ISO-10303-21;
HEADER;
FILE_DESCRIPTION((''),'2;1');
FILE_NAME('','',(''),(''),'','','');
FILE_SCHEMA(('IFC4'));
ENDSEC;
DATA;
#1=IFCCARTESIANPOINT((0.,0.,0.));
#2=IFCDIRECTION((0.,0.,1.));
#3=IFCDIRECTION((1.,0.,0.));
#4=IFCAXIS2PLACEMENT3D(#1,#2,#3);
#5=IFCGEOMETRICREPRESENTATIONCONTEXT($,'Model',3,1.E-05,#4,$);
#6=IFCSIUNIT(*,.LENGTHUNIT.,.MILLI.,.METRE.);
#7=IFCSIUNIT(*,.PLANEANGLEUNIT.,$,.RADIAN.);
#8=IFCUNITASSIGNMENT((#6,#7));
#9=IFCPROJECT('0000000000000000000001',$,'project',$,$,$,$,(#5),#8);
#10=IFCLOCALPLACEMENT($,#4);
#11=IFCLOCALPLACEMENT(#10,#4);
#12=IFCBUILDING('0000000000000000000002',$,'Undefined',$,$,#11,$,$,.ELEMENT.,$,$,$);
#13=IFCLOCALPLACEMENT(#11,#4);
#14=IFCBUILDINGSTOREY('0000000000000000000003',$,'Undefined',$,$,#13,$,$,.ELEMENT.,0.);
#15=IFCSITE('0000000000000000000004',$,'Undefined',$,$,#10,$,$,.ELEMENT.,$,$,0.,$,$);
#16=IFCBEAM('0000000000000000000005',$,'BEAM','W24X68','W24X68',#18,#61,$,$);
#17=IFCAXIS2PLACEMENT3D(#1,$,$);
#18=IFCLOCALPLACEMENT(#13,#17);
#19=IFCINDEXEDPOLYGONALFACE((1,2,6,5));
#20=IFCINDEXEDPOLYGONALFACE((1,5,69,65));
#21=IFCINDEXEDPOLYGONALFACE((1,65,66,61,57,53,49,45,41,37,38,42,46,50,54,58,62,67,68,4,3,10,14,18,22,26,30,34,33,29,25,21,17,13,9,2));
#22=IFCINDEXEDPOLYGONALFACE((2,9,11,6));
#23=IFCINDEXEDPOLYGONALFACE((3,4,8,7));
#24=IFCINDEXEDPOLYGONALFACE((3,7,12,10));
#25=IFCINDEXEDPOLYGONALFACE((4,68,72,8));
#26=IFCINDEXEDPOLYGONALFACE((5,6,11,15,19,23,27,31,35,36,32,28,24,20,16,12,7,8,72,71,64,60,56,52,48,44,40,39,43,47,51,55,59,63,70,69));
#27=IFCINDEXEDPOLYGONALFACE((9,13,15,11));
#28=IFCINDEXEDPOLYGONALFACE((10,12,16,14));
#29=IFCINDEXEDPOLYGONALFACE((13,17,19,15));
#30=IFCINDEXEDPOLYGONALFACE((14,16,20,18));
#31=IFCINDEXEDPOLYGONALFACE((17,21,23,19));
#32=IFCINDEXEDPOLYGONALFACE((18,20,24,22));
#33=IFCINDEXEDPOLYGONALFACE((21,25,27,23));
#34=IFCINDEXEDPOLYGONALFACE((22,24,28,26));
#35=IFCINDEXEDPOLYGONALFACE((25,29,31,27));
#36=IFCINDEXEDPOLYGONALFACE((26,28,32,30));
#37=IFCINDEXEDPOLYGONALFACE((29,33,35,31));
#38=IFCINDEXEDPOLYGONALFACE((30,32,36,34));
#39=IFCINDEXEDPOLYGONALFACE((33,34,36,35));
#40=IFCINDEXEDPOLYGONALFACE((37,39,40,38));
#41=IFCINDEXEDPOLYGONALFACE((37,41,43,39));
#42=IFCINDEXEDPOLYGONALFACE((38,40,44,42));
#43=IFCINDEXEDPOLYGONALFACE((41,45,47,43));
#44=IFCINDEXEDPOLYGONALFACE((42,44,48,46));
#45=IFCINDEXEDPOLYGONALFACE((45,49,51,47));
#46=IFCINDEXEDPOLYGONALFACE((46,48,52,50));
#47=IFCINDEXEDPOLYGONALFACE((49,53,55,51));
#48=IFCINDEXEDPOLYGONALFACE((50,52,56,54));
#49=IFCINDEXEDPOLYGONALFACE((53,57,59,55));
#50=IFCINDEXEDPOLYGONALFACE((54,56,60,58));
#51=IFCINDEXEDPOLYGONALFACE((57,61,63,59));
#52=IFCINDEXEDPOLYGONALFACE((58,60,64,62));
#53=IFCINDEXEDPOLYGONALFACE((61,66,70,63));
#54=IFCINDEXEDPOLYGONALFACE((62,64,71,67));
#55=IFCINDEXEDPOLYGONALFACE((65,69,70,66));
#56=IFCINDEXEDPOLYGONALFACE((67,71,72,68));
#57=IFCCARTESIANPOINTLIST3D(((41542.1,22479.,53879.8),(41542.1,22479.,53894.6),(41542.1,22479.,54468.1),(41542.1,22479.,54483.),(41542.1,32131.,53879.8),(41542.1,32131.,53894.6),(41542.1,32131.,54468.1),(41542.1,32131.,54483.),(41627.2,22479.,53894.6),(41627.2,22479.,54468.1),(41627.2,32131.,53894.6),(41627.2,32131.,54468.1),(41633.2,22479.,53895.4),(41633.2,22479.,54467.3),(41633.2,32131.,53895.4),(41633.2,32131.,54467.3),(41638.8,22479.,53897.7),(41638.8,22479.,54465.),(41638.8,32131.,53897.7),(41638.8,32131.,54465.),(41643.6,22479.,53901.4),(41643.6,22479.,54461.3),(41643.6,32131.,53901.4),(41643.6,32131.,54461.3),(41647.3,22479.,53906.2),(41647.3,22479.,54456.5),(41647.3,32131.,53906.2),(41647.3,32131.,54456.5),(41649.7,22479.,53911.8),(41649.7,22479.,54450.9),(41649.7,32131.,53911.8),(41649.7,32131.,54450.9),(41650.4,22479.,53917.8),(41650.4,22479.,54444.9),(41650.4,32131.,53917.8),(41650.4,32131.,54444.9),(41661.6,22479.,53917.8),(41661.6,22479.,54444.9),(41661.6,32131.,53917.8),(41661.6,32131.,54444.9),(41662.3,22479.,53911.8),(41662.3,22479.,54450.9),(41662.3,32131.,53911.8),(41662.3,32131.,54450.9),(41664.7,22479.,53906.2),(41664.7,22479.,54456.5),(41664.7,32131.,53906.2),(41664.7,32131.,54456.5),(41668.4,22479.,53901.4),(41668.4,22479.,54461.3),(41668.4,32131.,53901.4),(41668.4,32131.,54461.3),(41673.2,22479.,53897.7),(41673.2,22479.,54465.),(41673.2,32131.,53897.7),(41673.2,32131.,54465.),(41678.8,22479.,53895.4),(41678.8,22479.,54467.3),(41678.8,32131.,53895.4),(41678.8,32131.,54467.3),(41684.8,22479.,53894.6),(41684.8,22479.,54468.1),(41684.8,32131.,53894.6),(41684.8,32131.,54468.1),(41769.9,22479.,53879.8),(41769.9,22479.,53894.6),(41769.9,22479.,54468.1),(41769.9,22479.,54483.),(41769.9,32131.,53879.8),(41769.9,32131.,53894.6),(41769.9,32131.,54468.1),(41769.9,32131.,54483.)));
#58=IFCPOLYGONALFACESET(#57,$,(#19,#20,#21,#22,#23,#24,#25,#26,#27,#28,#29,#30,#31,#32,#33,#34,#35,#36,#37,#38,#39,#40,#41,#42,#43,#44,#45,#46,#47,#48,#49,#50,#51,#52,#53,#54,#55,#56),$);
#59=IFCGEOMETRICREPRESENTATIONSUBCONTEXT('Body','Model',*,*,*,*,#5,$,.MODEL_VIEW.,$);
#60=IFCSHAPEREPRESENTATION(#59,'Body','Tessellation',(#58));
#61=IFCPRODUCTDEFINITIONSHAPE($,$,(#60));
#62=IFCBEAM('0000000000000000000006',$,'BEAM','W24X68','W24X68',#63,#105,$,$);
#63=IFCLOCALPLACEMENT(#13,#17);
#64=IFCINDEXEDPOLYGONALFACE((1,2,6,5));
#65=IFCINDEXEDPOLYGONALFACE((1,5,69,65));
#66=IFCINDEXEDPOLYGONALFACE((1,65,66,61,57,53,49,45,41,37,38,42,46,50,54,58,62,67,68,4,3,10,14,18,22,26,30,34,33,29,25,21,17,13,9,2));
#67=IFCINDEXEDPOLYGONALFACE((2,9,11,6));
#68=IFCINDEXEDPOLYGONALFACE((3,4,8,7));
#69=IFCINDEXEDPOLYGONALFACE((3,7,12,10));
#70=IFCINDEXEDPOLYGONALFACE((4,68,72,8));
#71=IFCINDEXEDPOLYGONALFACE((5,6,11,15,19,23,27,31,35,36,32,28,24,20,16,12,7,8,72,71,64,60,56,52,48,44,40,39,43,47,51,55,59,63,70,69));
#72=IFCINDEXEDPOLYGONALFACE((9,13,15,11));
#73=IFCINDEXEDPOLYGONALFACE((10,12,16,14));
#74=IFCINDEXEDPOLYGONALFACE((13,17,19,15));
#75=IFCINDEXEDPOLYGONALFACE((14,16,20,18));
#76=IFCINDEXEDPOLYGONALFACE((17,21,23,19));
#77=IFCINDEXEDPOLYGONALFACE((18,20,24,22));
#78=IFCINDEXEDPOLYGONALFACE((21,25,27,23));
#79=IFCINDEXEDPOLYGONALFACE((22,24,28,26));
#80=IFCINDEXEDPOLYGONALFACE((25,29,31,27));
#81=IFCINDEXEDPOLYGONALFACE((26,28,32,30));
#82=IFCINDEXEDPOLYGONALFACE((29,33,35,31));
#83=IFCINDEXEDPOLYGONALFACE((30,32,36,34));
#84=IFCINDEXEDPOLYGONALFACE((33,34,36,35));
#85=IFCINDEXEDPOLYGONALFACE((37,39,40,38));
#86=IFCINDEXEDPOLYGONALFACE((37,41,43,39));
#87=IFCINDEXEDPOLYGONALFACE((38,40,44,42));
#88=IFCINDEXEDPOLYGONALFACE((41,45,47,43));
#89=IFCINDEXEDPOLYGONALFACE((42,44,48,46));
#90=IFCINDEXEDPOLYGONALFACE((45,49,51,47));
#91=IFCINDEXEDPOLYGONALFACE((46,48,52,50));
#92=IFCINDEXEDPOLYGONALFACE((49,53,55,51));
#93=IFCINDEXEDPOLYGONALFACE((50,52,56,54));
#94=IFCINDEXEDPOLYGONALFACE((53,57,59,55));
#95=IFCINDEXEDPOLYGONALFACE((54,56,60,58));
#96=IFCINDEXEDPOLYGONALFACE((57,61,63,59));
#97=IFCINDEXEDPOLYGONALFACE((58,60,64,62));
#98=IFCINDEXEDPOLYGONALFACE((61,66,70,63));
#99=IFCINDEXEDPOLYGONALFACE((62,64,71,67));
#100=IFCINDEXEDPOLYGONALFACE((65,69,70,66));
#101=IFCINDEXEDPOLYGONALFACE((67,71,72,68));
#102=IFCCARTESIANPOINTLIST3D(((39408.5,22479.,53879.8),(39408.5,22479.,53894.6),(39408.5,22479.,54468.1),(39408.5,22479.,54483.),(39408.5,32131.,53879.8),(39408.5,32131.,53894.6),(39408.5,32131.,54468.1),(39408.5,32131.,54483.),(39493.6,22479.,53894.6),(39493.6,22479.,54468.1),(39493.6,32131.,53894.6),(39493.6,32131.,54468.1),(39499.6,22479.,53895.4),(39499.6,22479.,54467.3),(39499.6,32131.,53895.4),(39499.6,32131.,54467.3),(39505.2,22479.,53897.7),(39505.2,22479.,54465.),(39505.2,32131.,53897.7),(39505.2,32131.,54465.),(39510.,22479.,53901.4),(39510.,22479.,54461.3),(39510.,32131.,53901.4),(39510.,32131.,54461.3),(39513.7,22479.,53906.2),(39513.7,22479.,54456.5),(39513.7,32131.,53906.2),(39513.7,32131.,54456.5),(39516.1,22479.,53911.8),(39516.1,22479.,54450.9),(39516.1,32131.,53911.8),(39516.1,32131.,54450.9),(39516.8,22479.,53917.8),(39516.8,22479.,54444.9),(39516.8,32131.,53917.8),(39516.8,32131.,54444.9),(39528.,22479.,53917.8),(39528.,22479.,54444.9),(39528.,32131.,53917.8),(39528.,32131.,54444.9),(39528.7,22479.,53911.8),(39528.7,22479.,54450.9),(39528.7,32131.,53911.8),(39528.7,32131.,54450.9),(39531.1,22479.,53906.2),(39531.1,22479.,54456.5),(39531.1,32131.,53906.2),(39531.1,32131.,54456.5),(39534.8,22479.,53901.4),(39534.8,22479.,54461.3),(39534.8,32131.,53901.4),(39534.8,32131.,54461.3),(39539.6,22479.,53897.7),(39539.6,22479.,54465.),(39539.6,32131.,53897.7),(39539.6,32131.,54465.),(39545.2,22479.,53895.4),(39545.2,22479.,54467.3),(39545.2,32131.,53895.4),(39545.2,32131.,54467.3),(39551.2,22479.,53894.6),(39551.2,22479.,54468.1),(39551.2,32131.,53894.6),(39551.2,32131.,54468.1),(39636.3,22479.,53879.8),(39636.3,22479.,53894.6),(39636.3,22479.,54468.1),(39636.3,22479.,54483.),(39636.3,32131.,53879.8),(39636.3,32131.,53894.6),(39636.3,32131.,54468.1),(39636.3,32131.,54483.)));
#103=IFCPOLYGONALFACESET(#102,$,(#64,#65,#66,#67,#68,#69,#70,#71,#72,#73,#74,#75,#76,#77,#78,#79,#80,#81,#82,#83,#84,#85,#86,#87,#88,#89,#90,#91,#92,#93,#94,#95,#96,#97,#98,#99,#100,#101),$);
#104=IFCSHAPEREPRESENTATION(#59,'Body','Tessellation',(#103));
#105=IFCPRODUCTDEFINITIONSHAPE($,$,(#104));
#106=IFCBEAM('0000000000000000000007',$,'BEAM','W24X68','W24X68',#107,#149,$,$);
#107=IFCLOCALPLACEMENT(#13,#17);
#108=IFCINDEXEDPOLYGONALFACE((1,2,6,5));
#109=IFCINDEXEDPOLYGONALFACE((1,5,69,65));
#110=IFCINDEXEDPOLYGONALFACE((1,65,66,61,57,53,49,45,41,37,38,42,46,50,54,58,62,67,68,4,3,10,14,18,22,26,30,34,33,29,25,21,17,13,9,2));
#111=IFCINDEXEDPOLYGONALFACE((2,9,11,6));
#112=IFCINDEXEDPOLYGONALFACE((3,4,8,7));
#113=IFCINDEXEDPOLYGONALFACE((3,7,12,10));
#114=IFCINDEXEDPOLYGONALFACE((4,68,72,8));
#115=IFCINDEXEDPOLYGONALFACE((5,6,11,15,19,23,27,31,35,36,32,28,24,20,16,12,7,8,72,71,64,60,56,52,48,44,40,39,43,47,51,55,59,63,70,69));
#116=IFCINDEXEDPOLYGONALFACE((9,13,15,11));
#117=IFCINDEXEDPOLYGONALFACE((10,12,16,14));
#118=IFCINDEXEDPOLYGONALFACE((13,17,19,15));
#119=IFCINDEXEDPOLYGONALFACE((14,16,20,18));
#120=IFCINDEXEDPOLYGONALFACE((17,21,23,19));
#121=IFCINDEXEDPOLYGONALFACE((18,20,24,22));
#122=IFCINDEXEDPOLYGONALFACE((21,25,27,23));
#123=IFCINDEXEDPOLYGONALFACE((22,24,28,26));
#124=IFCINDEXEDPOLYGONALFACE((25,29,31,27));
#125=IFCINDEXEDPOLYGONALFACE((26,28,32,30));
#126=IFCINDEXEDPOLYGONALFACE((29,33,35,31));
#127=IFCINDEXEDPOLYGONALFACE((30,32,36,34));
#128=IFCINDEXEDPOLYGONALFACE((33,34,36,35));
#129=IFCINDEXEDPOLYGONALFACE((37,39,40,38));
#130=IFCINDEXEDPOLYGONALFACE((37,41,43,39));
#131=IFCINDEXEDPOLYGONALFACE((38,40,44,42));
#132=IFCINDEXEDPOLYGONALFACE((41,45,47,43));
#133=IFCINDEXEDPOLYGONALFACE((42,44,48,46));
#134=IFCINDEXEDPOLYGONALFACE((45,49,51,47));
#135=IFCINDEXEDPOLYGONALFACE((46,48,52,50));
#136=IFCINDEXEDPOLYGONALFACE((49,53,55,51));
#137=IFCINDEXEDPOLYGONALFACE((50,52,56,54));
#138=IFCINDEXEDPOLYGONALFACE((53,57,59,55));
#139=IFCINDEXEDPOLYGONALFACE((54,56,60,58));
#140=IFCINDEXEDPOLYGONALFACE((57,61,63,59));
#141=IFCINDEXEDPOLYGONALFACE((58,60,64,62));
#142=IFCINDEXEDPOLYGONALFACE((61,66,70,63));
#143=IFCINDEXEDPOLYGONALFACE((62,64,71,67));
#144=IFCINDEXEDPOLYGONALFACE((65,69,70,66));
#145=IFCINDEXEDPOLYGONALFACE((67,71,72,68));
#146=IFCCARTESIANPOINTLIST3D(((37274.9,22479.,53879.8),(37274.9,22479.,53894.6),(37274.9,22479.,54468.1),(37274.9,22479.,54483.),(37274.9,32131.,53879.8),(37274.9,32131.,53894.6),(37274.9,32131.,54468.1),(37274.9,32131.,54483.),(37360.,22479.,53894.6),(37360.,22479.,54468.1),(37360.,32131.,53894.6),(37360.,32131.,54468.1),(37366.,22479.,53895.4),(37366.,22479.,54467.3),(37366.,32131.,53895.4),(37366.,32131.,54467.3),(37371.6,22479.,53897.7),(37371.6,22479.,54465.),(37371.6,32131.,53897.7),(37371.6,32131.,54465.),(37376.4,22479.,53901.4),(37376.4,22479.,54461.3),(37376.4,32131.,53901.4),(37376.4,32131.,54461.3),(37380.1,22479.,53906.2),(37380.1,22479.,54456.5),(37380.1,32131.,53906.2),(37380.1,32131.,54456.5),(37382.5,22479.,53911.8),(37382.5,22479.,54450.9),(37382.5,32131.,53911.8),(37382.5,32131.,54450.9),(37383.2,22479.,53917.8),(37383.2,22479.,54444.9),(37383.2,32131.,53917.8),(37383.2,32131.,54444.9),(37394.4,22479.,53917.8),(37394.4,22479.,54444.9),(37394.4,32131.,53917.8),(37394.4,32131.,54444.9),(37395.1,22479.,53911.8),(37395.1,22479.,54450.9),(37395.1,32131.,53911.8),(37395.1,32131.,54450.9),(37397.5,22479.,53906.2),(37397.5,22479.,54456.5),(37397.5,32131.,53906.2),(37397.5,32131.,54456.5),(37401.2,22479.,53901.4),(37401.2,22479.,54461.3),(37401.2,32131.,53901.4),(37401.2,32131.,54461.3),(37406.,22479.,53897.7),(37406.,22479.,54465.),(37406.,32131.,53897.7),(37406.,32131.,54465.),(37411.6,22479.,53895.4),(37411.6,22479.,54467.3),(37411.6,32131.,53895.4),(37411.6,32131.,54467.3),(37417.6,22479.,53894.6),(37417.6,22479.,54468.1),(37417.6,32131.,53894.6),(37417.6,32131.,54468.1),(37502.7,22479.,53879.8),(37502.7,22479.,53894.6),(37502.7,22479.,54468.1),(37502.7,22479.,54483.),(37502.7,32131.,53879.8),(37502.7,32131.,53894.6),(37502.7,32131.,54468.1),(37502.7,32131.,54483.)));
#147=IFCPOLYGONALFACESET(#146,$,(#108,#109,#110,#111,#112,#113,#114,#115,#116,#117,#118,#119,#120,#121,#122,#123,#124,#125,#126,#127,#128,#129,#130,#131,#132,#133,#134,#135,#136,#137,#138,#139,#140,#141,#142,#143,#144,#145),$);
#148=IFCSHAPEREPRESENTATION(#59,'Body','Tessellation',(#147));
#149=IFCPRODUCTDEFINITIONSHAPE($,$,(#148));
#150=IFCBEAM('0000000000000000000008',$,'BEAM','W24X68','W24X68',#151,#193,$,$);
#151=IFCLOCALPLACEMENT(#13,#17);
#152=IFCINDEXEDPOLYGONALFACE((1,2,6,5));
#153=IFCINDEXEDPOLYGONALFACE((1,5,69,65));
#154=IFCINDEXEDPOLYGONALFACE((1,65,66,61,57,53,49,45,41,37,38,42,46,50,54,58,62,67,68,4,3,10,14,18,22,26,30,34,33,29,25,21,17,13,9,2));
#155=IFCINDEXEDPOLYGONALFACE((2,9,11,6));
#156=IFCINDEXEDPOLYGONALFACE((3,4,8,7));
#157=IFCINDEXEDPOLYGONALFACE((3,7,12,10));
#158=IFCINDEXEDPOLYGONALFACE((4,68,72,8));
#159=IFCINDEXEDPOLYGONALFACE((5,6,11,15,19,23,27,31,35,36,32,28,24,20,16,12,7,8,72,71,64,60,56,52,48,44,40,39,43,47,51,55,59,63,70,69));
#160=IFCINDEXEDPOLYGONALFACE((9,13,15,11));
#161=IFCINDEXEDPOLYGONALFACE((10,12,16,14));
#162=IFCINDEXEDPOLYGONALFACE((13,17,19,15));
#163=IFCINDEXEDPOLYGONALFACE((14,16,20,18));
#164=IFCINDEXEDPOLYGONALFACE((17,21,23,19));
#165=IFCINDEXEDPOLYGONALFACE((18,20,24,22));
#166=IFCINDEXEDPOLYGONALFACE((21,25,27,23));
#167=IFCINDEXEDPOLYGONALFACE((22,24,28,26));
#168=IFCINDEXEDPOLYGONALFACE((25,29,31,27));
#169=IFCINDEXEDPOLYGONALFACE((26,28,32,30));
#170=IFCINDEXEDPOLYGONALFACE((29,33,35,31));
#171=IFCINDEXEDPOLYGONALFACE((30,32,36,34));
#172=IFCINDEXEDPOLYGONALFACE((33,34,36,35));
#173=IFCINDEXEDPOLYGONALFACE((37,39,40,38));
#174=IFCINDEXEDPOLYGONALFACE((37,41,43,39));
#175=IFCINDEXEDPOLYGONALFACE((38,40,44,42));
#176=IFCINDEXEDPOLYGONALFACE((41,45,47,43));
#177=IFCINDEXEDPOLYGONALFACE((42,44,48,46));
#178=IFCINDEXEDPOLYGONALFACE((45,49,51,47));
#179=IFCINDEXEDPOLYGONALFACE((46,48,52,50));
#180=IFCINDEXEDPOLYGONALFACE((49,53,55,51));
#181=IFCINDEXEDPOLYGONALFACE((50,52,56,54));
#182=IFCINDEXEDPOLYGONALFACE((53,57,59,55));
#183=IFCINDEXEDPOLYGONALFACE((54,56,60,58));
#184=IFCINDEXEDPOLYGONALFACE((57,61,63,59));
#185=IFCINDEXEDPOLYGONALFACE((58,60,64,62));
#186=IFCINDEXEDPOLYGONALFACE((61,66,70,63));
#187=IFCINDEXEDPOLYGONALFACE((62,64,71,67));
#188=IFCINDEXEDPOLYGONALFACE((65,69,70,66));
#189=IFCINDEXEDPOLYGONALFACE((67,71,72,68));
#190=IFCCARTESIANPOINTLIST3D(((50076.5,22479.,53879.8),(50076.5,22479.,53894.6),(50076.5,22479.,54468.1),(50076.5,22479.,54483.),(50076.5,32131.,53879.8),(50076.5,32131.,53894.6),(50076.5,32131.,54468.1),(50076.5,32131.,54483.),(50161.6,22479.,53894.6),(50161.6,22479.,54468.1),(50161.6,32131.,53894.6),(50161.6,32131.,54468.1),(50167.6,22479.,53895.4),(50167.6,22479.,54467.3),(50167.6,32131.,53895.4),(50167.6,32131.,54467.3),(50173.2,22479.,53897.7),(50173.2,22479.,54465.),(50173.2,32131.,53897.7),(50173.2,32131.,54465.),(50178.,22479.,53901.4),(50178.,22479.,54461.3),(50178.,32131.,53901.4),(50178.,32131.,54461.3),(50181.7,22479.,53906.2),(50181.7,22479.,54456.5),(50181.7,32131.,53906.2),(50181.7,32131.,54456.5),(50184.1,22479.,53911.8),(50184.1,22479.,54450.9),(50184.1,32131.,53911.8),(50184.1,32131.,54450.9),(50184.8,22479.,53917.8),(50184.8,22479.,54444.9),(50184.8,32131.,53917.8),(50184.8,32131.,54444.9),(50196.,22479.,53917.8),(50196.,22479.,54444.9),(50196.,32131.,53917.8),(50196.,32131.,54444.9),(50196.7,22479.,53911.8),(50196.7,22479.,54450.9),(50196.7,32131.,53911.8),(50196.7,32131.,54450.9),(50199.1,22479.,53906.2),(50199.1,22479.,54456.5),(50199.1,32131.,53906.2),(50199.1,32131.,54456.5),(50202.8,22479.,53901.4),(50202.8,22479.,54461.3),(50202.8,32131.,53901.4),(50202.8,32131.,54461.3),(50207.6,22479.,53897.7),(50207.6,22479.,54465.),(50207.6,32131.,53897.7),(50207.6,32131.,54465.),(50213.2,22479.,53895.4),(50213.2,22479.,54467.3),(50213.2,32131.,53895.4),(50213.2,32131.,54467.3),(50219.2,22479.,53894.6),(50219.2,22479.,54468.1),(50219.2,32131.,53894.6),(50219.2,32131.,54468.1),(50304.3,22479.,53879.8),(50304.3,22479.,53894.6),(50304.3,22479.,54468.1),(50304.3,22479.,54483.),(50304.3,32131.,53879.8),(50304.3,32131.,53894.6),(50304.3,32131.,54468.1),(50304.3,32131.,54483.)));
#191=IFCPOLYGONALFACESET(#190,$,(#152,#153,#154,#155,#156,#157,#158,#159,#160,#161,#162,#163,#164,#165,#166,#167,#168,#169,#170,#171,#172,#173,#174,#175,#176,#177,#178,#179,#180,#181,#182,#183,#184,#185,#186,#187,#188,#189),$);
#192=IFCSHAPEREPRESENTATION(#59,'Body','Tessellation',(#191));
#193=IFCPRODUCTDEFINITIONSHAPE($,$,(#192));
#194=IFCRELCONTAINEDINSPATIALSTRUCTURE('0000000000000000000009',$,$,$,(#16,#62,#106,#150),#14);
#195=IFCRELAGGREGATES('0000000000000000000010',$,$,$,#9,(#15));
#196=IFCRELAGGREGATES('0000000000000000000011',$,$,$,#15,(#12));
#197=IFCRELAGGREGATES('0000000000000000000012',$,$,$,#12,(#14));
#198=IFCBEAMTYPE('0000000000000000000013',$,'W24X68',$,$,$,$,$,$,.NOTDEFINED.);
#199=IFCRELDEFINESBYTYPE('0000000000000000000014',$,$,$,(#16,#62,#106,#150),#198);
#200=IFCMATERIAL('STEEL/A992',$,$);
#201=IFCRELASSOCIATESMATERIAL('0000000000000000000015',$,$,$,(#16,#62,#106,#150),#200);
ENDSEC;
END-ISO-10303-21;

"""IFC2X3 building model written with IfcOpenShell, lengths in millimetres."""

from ifc_helpers import new_model, si_unit, frame, origin_with_axes, origin_2d_with_axis, place, context, subcontext, project, spatial, i_section, extrude, material, type_object, element, save


model = new_model("IFC2X3")

# Units and contexts
model_context = context("Model", 3, precision=1e-05, world=origin_with_axes())
body_context = subcontext(model_context, "Body", "Model", "MODEL_VIEW")
ifc_project = project(units=[si_unit("LENGTHUNIT", "METRE", prefix="MILLI"), si_unit("PLANEANGLEUNIT", "RADIAN")], contexts=[model_context])

# Site, building, storey
site_placement = place(None, origin_with_axes())
site = spatial("IfcSite", under=ifc_project, at=site_placement, Name="Undefined", CompositionType="ELEMENT", RefElevation=0.0)
building_placement = place(site_placement, origin_with_axes())
building = spatial("IfcBuilding", under=site, at=building_placement, Name="Undefined", CompositionType="ELEMENT")
storey_placement = place(building_placement, origin_with_axes())
storey = spatial("IfcBuildingStorey", under=building, at=storey_placement, Name="Undefined", CompositionType="ELEMENT", Elevation=0.0)

# Shared definitions
ifc_material = material(Name="STEEL/A992")

# Beams
beam_type = type_object("IfcBeamType", Name="W24X68", PredefinedType="NOTDEFINED")
for number, where, z_axis, x_axis, name in (
    (1, (41656.0, 22479.0, 54181.4), (0.0, 0.0, 1.0), (0.0, 1.0, 0.0), "BEAM"),
    (2, (39522.4, 22479.0, 54181.4), (0.0, 0.0, 1.0), (0.0, 1.0, 0.0), "BEAM"),
    (3, (37388.8, 22479.0, 54181.4), (0.0, 0.0, 1.0), (0.0, 1.0, 0.0), "BEAM"),
    (4, (50190.4, 22479.0, 54181.4), (0.0, 0.0, 1.0), (0.0, 1.0, 0.0), "BEAM"),
):
    element("IfcBeam", number, at=place(storey_placement, frame(where, z_axis=z_axis, x_axis=x_axis)), inside=storey, type_object=beam_type, material=ifc_material, Name=name, Description="W24X68", ObjectType="W24X68", context=body_context, shape_type="SweptSolid", body=[
        extrude(i_section(OverallWidth=227.8, OverallDepth=603.2, WebThickness=11.1, FlangeThickness=14.9, FilletRadius=23.2, at=origin_2d_with_axis()), frame((9652.0, 0.0, 0.0), z_axis=(-1.0, 0.0, 0.0), x_axis=(0.0, -1.0, 0.0)), (0.0, 0.0, 1.0), 9652.0),
    ])

save(model, "model.ifc")
